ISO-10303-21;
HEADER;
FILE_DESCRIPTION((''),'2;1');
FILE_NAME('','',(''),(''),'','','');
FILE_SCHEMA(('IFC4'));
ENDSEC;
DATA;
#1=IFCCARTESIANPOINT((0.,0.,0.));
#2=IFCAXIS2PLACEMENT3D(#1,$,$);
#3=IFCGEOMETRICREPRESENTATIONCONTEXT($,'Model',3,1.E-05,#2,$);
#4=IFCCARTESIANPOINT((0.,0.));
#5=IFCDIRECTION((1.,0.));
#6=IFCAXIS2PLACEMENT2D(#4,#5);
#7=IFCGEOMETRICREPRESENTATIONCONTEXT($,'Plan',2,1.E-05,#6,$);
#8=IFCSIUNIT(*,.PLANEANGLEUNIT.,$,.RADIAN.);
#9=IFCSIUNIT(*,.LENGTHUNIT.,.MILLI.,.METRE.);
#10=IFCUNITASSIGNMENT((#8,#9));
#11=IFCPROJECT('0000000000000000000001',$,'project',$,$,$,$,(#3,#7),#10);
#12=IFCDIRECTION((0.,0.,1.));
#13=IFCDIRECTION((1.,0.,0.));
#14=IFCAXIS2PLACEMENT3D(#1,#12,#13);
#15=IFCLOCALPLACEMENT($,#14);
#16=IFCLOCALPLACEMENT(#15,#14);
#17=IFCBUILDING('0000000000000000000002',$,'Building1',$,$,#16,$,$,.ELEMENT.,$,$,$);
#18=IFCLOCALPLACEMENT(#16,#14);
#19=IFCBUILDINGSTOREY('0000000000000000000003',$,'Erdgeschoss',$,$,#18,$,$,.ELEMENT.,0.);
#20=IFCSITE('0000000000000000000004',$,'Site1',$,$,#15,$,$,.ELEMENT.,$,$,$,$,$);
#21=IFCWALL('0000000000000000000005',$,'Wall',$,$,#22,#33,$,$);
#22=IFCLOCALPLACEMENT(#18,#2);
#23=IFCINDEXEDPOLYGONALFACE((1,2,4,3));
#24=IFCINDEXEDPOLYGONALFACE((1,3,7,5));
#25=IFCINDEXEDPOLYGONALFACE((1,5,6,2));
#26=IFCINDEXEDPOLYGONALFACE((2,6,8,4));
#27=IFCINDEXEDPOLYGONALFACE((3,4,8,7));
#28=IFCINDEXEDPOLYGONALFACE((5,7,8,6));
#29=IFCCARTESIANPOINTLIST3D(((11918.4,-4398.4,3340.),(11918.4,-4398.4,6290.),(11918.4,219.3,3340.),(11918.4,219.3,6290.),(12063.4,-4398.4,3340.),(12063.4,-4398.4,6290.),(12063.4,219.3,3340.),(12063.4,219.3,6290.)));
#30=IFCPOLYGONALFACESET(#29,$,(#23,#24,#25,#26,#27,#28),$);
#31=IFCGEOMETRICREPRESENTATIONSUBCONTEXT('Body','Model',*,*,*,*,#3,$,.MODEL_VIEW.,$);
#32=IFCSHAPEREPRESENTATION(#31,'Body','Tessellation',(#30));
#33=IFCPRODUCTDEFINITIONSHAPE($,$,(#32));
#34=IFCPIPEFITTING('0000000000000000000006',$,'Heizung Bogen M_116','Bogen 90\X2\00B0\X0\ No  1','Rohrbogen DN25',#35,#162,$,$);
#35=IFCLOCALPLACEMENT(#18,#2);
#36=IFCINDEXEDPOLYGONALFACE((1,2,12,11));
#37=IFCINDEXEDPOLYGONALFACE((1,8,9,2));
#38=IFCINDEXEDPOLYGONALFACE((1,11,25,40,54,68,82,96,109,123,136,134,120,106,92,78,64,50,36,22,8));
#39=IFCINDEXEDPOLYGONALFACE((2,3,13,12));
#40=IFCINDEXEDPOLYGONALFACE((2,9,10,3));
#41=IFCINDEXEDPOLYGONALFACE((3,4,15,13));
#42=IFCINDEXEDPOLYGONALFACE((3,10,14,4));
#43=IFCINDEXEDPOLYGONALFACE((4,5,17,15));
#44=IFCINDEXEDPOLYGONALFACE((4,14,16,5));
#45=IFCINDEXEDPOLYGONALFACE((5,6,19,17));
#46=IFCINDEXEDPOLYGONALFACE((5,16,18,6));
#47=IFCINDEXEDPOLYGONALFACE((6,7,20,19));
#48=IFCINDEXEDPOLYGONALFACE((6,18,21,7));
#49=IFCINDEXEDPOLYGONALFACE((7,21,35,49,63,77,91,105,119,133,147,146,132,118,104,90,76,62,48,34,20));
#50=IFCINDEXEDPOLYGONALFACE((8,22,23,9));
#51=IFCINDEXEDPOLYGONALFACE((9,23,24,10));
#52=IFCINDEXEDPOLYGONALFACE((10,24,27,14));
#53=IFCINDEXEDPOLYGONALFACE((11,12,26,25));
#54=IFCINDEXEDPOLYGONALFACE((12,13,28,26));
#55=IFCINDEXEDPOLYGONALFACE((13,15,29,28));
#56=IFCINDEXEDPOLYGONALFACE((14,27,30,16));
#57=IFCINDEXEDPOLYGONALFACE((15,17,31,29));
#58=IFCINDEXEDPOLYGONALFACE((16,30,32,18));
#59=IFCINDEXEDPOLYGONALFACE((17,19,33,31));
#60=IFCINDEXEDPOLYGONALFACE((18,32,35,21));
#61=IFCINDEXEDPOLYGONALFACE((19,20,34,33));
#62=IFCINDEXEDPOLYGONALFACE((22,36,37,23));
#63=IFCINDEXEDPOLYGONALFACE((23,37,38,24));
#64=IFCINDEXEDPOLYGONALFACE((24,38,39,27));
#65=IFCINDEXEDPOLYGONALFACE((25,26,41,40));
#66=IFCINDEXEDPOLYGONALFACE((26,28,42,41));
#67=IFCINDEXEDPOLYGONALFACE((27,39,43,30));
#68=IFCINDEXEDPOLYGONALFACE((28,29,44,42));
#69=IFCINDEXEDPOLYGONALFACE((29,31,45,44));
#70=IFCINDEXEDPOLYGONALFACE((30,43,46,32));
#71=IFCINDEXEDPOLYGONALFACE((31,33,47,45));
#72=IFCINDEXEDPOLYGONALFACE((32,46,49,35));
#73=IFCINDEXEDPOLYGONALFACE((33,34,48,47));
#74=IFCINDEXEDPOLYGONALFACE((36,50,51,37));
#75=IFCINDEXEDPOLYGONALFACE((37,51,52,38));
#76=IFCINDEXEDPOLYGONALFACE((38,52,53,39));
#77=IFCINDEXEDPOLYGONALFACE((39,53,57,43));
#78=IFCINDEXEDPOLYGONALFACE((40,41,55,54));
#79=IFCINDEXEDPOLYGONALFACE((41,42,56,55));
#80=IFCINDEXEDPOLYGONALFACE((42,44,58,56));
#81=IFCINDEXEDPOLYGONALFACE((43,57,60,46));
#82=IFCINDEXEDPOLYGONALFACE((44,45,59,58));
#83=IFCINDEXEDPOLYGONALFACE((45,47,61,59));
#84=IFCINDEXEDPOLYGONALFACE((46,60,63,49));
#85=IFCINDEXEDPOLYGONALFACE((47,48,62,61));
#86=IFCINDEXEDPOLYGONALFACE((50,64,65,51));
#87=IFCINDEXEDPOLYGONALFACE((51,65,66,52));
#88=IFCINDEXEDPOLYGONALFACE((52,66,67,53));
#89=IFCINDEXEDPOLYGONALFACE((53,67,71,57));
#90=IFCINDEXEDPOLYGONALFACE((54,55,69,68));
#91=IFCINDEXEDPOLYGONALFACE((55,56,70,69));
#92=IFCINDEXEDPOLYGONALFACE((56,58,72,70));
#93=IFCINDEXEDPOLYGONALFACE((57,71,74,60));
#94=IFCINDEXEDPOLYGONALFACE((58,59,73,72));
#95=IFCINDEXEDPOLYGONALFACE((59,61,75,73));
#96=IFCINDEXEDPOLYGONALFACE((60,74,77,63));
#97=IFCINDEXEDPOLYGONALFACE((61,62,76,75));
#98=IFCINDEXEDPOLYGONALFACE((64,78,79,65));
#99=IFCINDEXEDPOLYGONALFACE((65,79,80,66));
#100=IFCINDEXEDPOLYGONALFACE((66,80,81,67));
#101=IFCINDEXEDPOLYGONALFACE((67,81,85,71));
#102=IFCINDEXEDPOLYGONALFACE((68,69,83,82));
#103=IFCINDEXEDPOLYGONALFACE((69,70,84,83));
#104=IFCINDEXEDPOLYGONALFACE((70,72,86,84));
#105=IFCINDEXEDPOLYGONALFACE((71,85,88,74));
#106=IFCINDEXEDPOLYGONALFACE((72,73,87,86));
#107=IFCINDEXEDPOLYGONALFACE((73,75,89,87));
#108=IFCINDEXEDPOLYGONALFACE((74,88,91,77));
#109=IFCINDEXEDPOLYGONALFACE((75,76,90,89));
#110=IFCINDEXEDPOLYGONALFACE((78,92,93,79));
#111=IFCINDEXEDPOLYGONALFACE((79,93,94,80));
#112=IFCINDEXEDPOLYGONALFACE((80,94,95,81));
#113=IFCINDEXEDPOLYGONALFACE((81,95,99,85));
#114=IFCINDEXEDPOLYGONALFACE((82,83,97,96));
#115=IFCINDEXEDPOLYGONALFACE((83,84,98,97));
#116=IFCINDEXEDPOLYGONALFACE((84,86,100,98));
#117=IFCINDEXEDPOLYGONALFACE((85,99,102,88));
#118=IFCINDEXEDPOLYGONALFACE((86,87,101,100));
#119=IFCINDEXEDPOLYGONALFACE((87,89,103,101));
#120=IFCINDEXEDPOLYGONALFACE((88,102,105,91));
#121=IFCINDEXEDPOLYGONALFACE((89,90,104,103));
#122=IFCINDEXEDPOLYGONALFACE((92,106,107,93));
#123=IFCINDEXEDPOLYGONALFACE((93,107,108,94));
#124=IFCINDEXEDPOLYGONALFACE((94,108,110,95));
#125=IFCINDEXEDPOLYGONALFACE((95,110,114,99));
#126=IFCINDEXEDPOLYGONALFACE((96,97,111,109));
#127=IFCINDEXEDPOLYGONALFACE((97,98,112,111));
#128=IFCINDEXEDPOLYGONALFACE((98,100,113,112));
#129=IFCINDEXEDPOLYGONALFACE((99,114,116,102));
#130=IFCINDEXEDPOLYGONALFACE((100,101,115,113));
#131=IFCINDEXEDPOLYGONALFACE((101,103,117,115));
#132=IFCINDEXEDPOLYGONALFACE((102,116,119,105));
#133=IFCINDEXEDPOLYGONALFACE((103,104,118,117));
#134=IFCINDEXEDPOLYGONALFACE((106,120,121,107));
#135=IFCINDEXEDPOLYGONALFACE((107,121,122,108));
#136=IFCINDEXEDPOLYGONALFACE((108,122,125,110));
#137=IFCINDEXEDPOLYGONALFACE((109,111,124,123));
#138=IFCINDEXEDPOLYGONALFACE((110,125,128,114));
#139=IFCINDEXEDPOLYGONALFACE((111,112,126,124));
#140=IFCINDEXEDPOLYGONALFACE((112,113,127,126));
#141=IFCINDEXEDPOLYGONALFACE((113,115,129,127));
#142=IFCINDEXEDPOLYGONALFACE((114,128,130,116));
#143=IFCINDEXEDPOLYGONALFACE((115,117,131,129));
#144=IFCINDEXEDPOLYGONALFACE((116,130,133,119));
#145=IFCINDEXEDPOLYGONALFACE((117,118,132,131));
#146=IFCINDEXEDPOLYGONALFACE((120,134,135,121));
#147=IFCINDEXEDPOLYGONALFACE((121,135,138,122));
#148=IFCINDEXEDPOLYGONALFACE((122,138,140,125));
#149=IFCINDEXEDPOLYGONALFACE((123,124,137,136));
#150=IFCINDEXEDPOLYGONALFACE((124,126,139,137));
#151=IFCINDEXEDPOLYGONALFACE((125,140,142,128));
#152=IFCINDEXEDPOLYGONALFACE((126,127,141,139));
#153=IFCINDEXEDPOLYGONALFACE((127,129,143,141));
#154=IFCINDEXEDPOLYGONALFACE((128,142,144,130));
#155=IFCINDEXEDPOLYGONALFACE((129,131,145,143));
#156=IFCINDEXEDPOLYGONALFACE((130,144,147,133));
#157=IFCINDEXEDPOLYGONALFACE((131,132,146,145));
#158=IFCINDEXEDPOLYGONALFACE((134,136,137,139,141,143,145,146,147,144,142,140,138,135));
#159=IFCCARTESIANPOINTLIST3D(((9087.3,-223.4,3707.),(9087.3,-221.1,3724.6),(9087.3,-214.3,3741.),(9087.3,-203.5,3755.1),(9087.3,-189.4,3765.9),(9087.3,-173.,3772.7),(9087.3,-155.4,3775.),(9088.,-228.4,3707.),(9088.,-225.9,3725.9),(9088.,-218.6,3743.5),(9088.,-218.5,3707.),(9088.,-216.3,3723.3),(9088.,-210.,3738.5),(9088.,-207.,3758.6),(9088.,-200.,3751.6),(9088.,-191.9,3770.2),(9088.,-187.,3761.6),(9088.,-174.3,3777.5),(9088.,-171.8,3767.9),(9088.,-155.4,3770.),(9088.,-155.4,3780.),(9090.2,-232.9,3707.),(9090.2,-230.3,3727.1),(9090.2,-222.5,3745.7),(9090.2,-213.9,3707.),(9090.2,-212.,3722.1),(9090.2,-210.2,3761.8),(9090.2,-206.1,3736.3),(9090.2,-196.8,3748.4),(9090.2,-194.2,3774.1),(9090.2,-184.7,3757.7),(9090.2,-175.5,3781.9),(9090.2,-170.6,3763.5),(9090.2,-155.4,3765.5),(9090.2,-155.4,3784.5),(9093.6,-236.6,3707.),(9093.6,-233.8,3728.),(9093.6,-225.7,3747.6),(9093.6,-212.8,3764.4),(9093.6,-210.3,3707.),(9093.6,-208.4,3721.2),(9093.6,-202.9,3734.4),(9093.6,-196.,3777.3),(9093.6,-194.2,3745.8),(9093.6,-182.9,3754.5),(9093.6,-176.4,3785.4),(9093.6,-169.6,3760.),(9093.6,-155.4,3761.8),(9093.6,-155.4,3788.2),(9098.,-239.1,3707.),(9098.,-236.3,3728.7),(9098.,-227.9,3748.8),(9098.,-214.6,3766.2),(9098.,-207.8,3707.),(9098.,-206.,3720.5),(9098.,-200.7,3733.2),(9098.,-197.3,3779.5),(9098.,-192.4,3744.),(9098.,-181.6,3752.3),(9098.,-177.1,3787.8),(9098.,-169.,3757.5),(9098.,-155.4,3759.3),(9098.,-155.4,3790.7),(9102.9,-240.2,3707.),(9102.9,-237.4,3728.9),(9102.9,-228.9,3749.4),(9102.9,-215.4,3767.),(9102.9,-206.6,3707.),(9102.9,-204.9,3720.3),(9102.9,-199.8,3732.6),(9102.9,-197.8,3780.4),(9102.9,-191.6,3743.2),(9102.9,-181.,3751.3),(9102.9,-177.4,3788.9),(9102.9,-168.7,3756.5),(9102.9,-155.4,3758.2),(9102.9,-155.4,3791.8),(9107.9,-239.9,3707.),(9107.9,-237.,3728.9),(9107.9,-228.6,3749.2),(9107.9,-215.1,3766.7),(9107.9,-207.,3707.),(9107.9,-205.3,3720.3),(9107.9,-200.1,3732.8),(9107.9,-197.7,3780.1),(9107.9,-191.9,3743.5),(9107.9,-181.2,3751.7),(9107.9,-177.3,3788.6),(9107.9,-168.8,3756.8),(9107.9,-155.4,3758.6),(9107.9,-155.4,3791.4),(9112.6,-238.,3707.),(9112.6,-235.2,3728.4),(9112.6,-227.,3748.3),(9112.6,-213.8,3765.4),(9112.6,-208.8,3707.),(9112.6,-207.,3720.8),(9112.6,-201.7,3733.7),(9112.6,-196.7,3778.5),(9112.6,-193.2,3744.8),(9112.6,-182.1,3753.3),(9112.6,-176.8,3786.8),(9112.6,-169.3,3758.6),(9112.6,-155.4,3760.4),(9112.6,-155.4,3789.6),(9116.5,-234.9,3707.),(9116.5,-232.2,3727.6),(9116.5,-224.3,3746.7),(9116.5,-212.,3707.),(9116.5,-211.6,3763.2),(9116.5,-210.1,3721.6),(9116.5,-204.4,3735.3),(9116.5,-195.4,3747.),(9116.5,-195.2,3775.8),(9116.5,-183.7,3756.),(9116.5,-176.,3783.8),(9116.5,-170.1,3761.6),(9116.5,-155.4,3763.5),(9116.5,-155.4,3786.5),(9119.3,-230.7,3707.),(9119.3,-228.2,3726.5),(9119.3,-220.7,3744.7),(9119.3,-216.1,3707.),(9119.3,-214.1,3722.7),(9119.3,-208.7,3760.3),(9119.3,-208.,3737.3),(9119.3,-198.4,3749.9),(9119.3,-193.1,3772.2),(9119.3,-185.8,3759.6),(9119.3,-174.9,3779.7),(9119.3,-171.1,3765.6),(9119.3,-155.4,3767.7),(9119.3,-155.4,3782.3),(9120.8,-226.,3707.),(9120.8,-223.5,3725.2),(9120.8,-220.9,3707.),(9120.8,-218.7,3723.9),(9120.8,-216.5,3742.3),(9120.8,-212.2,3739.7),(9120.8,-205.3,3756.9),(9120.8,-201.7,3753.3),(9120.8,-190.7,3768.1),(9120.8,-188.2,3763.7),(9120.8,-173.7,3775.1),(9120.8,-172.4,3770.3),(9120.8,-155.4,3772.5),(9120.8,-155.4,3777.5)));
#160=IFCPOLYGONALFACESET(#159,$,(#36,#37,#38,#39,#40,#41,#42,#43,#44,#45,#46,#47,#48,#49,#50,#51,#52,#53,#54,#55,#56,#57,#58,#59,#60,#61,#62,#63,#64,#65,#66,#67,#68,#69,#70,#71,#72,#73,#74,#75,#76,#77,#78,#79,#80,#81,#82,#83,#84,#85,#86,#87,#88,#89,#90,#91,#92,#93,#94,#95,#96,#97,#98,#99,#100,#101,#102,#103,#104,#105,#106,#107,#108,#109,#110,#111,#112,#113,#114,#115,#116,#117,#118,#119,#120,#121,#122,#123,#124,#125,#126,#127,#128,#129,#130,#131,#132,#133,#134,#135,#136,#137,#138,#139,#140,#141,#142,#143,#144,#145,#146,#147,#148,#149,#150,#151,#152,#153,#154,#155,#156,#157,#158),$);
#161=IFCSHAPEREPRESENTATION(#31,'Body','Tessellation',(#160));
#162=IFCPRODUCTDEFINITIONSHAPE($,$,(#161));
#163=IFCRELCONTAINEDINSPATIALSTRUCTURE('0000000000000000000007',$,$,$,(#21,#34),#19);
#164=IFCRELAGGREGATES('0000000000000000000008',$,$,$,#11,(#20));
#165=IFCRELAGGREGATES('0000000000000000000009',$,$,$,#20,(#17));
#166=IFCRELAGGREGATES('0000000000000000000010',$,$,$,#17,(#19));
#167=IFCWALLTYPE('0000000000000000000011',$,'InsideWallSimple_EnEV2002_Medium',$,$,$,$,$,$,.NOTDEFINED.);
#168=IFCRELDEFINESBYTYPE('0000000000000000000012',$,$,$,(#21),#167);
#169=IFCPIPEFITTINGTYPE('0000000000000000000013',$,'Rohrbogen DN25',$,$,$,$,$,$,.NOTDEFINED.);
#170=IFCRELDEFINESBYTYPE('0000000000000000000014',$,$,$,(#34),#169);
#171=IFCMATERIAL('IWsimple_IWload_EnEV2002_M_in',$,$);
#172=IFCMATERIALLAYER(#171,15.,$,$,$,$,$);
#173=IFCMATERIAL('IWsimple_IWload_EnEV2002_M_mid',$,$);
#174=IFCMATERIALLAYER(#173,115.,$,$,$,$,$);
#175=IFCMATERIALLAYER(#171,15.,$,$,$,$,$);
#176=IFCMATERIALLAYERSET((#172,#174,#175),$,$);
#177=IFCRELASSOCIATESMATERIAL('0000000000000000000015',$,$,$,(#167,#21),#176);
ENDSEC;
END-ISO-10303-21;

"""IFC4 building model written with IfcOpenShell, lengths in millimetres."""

from ifc_helpers import new_model, entity, si_unit, frame, origin, origin_with_axes, origin_2d_with_axis, place, context, subcontext, project, spatial, indexed_curve, outline, extrude, shape, source, transform, mapped, material, layer, layer_set, layer_usage, type_object, element, save


model = new_model("IFC4")

# Units and contexts
model_context = context("Model", 3, precision=1e-05, world=origin())
plan_context = context("Plan", 2, precision=1e-05, world=origin_2d_with_axis())
body_context = subcontext(model_context, "Body", "Model", "MODEL_VIEW")
ifc_project = project(units=[si_unit("PLANEANGLEUNIT", "RADIAN"), si_unit("LENGTHUNIT", "METRE", prefix="MILLI")], contexts=[model_context, plan_context])

# Site, building, storey
site_placement = place(None, origin_with_axes())
site = spatial("IfcSite", under=ifc_project, at=site_placement, Name="Site1", CompositionType="ELEMENT")
building_placement = place(site_placement, origin_with_axes())
building = spatial("IfcBuilding", under=site, at=building_placement, Name="Building1", CompositionType="ELEMENT")
storey_placement = place(building_placement, origin_with_axes())
storey = spatial("IfcBuildingStorey", under=building, at=storey_placement, Name="Erdgeschoss", CompositionType="ELEMENT", Elevation=0.0)

# Wall
ifc_material_1 = material(Name="IWsimple_IWload_EnEV2002_M_in")
ifc_layer_1 = layer(ifc_material_1, 15.0)
ifc_material_2 = material(Name="IWsimple_IWload_EnEV2002_M_mid")
ifc_layer_2 = layer(ifc_material_2, 115.0)
ifc_layer_3 = layer(ifc_material_1, 15.0)
ifc_layer_set = layer_set([ifc_layer_1, ifc_layer_2, ifc_layer_3])
ifc_layer_usage = layer_usage(ifc_layer_set, "AXIS2", "POSITIVE", 0.0)
wall_type = type_object("IfcWallType", Name="InsideWallSimple_EnEV2002_Medium", PredefinedType="NOTDEFINED", material=ifc_layer_set)
wall_placement = place(storey_placement, frame((11918.4, 219.3, 3340.0), z_axis=(0.0, 0.0, 1.0), x_axis=(-0.000001, -1.0, 0.0)))
element("IfcWall", 1, at=wall_placement, inside=storey, type_object=wall_type, material=ifc_layer_usage, Name="Wall", context=body_context, shape_type="SweptSolid", body=[
    extrude(outline(indexed_curve([(0.0, 0.0), (0.0, 145.0), (4617.6, 145.0), (4617.6, 0.0), (0.0, 0.0)], self_intersect=False)), origin_with_axes(), (0.0, 0.0, 1.0), 2950.0),
])

# Pipe fitting
pipe_fitting_type = type_object("IfcPipeFittingType", Name="Rohrbogen DN25", PredefinedType="NOTDEFINED")
shared_shape_1 = source(origin_with_axes(), body_context, "Body", "SolidModel", [
    entity("IfcRevolvedAreaSolid", entity("IfcCircleProfileDef", "AREA", None, entity("IfcAxis2Placement2D", entity("IfcCartesianPoint", [0.0, 0.0]), entity("IfcDirection", [1.0, 0.0])), 16.9), entity("IfcAxis2Placement3D", entity("IfcCartesianPoint", [-42.4, 0.0, 25.6]), entity("IfcDirection", [1.0, 0.0, 0.0]), entity("IfcDirection", [0.0, -1.0, 0.0])), entity("IfcAxis1Placement", entity("IfcCartesianPoint", [0.0, 68.0, 0.0]), entity("IfcDirection", [-1.0, 0.0, 0.0])), 1.570796),
])
for number, where, z_axis, x_axis, name in (
    (2, (9104.1, -197.9, 3749.4), (0.0, 0.0, 1.0), (1.0, 0.0, 0.0), "Heizung Bogen M_116"),
):
    element("IfcPipeFitting", number, at=place(storey_placement, frame(where, z_axis=z_axis, x_axis=x_axis)), inside=storey, type_object=pipe_fitting_type, Name=name, Description="Bogen 90° No  1", ObjectType="Rohrbogen DN25", shapes=[
        shape(body_context, "Body", "MappedRepresentation", [mapped(shared_shape_1, transform((0.0, 0.0, 0.0), x_axis=(0.0, -1.0, 0.0), y_axis=(1.0, 0.0, 0.0), z_axis=(0.0, 0.0, 1.0), scale=1.0))]),
        shape(body_context, "Body", "MappedRepresentation", [mapped(shared_shape_1, transform((0.0, 0.0, 0.0), x_axis=(0.0, -1.0, 0.0), y_axis=(1.0, 0.0, 0.0), z_axis=(0.0, 0.0, 1.0), scale=1.0))]),
    ])

save(model, "model.ifc")
